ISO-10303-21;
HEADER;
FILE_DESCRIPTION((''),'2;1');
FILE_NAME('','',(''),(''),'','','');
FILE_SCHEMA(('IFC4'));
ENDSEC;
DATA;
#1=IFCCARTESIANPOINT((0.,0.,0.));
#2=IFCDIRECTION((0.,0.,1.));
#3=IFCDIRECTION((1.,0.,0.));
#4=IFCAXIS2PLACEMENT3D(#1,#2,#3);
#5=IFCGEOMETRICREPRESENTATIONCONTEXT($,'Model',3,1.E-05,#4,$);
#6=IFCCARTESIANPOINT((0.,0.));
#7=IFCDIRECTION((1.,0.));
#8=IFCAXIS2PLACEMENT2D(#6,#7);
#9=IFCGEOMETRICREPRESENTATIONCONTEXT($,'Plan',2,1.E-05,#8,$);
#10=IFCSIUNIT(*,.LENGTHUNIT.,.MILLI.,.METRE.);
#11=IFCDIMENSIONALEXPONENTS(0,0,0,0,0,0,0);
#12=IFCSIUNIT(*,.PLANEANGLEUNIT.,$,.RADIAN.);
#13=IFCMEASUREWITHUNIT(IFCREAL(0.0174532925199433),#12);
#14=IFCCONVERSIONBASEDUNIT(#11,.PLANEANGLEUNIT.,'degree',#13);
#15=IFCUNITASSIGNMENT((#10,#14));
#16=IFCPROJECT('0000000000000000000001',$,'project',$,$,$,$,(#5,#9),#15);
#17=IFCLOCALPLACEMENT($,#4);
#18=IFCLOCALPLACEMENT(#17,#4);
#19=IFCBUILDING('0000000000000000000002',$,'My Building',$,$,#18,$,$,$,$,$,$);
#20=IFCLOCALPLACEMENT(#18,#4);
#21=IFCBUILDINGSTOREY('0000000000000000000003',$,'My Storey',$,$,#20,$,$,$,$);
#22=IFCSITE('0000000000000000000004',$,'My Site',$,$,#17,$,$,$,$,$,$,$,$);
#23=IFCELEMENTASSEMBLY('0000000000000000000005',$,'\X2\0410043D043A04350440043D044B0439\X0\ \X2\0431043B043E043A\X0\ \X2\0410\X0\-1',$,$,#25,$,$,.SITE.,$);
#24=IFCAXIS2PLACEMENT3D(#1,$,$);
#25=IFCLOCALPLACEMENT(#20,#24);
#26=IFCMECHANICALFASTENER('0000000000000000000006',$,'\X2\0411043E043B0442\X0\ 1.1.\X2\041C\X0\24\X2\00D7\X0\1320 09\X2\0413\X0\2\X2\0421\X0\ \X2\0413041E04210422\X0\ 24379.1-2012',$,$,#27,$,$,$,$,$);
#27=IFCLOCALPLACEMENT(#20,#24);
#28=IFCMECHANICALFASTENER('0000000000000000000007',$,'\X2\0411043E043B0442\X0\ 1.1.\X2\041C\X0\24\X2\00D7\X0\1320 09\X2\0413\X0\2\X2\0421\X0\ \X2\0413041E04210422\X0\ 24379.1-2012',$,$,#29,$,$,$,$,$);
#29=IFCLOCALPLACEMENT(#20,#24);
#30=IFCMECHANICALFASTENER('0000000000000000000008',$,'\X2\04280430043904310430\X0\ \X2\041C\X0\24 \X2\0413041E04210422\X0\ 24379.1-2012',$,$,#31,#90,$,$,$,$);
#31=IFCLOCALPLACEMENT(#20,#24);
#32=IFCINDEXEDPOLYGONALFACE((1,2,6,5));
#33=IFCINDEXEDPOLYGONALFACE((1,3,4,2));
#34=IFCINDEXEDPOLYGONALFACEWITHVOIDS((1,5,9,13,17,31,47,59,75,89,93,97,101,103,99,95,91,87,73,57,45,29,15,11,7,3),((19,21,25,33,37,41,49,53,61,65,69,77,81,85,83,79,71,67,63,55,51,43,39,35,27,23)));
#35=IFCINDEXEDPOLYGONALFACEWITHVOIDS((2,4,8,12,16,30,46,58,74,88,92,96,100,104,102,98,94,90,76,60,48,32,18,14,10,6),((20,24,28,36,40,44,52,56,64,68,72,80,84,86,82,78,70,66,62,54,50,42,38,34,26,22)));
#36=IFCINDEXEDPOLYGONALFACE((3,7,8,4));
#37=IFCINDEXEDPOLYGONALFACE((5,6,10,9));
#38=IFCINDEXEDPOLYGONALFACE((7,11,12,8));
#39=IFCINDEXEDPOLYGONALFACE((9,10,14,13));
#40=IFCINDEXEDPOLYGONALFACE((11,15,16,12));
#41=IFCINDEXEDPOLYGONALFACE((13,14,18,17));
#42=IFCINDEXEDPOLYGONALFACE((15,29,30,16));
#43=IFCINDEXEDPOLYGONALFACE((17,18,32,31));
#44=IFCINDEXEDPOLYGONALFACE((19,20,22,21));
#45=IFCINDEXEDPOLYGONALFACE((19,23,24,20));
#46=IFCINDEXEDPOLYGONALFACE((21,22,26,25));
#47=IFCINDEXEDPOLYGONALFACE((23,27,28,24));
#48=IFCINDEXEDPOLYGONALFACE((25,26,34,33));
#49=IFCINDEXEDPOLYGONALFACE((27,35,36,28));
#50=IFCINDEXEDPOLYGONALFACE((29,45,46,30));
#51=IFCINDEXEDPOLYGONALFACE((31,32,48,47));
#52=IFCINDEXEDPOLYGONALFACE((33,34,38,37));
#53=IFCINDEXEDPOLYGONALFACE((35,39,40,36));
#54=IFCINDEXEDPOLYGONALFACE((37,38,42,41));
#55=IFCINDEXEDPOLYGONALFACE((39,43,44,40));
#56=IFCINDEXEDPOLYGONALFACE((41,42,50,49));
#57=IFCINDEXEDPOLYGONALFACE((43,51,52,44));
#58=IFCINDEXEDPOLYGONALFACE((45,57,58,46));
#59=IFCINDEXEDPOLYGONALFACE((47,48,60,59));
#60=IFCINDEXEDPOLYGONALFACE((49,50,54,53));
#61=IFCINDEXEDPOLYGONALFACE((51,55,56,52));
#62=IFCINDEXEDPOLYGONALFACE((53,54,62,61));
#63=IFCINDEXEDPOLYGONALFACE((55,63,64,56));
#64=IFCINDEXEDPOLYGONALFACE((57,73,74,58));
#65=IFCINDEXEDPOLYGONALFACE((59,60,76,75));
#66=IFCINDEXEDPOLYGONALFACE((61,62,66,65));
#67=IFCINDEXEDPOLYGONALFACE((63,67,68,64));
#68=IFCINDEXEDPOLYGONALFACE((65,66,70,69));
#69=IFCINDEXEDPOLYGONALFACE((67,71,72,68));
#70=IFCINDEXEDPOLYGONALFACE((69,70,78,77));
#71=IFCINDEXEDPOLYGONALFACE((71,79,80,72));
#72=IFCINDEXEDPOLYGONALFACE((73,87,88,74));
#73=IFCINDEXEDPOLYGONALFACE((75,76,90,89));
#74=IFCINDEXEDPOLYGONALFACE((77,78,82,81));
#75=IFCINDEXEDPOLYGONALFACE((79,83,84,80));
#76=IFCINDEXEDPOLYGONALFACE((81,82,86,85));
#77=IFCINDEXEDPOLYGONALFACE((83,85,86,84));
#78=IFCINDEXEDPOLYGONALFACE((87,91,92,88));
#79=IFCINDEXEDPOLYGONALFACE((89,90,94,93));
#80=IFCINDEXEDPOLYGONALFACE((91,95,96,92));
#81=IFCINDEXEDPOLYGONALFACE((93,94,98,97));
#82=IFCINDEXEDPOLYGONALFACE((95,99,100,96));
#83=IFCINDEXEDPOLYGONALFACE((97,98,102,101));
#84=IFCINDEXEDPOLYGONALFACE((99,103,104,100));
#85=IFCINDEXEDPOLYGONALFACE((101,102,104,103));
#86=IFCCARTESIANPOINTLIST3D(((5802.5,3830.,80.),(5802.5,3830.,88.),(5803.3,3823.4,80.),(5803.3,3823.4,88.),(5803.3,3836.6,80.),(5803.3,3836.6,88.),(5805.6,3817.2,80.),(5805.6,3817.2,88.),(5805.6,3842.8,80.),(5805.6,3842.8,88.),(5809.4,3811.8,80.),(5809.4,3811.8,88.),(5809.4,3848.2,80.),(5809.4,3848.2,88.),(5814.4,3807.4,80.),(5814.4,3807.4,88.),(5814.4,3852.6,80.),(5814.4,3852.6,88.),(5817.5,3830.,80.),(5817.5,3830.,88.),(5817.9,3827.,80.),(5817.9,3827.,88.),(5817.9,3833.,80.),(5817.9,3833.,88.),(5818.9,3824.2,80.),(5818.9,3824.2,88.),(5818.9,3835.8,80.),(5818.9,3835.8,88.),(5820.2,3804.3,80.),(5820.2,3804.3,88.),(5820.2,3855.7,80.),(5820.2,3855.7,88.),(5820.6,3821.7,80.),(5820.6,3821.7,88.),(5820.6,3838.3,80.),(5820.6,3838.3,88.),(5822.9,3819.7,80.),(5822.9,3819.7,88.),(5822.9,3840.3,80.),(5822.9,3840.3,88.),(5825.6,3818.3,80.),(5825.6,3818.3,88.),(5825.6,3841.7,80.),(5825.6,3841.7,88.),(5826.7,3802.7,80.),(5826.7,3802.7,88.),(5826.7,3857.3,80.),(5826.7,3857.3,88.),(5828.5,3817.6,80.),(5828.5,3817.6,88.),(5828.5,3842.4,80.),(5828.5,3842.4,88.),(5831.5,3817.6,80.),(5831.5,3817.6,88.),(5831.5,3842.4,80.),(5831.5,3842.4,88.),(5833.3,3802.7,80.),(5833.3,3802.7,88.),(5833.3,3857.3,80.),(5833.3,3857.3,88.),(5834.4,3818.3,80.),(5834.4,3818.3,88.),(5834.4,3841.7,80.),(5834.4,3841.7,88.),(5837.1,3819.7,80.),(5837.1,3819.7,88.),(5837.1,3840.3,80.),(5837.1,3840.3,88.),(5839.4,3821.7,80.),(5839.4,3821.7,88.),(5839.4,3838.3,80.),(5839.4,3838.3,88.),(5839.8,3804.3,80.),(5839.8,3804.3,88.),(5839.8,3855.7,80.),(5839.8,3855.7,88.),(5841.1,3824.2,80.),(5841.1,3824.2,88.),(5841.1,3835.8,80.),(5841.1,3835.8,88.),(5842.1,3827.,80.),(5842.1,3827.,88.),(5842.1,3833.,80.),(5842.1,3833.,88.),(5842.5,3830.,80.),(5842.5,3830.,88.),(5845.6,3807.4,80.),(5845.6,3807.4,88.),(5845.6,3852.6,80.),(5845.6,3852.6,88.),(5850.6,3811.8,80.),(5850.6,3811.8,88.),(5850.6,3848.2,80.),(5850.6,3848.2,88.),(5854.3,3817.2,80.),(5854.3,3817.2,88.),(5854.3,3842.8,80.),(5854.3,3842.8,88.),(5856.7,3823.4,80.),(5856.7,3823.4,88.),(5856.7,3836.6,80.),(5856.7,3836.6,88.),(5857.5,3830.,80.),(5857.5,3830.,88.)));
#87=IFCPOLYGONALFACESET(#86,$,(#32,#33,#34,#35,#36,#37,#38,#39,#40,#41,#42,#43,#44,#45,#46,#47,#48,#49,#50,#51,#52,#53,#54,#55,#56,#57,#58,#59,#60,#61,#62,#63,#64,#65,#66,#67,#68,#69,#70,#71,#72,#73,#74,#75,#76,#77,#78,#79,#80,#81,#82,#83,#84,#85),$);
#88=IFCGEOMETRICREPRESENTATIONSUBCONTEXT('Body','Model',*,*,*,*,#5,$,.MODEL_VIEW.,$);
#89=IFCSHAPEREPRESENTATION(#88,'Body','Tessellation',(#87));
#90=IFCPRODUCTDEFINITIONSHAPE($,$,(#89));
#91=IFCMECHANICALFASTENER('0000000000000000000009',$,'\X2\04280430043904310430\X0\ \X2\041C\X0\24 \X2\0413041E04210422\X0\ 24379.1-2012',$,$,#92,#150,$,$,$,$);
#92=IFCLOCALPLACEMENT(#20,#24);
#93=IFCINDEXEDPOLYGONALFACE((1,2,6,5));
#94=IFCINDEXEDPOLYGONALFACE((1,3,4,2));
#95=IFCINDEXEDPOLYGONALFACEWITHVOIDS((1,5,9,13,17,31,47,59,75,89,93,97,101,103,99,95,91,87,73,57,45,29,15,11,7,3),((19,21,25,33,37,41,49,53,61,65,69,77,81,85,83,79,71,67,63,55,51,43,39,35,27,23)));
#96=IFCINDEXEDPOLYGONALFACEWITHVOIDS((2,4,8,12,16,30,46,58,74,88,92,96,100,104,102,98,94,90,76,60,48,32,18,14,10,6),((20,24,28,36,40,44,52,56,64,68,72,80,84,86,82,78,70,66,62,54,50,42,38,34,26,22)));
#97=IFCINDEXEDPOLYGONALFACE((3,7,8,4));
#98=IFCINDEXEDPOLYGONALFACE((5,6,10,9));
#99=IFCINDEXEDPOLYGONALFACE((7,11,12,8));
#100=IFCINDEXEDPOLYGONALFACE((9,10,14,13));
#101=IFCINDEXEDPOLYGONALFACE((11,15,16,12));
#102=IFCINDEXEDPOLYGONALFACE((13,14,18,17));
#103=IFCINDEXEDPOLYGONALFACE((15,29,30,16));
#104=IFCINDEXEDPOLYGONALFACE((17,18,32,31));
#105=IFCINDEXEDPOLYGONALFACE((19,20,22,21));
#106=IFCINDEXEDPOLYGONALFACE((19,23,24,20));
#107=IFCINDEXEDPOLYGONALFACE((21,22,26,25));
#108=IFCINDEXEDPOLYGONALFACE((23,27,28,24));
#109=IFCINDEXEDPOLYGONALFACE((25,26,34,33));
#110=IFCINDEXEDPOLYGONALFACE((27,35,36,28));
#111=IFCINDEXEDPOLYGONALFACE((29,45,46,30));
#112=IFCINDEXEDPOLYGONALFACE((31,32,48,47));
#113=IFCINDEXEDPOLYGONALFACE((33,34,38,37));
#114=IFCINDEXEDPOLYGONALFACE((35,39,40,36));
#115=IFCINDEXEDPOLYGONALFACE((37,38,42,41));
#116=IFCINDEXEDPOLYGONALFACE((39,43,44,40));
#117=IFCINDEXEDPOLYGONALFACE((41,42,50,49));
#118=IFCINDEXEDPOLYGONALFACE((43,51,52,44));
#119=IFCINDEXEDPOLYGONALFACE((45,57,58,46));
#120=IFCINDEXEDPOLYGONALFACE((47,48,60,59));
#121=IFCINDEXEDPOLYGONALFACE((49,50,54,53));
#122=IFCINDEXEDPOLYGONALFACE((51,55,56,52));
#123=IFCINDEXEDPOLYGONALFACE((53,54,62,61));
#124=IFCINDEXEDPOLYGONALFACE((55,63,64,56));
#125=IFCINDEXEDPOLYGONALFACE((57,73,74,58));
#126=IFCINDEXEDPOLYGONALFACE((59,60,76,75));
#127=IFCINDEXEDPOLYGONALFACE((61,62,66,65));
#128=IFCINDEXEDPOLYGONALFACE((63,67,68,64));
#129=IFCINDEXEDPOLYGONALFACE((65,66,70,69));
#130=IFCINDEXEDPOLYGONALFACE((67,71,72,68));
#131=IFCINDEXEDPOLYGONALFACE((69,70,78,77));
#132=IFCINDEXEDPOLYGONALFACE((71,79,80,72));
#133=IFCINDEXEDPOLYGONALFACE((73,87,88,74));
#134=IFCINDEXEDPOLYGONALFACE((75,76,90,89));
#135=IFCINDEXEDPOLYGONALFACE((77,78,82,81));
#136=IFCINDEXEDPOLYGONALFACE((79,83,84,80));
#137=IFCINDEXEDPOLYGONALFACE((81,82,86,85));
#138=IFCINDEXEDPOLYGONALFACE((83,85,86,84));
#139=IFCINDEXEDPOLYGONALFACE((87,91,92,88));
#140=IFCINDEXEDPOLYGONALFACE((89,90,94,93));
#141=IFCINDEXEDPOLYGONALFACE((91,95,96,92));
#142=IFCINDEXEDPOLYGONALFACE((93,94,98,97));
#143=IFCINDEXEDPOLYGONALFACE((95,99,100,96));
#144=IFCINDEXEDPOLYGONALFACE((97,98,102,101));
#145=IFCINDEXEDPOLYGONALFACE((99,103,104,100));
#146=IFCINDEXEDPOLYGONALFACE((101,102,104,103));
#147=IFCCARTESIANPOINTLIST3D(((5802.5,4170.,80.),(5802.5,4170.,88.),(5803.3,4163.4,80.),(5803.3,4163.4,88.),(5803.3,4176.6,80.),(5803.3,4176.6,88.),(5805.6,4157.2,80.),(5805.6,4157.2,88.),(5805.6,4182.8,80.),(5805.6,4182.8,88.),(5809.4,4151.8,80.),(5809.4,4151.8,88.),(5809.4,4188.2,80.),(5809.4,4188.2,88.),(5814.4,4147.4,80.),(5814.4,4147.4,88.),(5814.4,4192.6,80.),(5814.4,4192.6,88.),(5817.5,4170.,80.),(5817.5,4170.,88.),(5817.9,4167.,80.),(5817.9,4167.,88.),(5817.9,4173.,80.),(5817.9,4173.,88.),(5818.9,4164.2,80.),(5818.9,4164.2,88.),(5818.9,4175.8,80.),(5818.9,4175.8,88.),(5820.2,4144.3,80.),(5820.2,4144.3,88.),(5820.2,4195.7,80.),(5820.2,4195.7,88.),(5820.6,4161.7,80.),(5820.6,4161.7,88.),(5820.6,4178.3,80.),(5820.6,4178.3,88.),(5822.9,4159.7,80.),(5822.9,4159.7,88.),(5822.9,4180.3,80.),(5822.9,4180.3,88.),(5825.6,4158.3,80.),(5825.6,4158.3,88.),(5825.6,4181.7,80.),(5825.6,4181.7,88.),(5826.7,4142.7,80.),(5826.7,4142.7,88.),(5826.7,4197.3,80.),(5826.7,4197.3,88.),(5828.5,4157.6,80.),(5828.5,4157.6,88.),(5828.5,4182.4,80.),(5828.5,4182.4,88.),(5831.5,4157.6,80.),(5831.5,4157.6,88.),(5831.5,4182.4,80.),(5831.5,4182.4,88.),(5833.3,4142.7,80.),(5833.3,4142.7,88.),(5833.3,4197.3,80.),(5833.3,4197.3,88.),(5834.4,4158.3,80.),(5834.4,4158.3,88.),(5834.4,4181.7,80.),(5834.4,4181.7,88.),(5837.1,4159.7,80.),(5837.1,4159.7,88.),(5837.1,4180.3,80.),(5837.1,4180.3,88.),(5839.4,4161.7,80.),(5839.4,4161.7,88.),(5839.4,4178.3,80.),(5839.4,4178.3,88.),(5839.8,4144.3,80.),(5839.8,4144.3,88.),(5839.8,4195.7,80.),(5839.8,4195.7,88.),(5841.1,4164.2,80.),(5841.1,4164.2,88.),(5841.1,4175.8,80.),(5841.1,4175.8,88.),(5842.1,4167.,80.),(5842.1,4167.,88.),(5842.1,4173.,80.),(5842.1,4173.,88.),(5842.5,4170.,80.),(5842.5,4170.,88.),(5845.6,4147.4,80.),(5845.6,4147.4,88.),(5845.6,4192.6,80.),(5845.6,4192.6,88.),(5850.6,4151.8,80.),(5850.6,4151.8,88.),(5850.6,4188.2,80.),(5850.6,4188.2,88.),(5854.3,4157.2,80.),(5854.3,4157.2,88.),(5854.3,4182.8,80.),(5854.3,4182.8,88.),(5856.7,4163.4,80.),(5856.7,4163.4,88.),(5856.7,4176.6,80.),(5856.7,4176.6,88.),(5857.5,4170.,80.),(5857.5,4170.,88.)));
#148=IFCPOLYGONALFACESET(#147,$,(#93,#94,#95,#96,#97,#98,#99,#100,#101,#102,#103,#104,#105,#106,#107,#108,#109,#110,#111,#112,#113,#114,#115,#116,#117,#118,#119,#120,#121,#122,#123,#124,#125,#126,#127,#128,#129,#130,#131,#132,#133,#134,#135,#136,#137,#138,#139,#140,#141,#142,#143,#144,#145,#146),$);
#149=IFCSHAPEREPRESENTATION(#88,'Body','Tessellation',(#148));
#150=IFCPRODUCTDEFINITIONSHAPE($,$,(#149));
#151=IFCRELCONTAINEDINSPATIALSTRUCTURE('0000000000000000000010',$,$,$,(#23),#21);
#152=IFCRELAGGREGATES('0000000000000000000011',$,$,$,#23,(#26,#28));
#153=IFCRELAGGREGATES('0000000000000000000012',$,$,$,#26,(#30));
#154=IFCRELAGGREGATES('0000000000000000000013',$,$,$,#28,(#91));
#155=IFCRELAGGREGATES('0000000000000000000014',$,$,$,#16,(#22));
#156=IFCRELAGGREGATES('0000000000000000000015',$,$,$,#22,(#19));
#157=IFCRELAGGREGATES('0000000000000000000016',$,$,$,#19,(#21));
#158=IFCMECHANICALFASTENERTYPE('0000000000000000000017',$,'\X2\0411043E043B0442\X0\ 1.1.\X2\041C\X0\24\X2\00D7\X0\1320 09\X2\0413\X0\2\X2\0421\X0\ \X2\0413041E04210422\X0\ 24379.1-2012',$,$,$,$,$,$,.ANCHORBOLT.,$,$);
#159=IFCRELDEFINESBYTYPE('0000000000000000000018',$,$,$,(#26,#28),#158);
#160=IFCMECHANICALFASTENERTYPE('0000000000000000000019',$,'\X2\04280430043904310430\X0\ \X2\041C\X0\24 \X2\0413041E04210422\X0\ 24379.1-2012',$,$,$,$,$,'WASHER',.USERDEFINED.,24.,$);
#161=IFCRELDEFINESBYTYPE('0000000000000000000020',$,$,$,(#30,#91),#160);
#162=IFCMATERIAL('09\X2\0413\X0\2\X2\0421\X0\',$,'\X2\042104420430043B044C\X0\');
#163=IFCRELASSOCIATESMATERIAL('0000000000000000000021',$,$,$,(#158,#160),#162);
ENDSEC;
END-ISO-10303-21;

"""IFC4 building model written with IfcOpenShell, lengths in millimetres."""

from ifc_helpers import new_model, entity, si_unit, converted_unit, frame, origin_with_axes, origin_2d_with_axis, place, context, subcontext, project, spatial, polyline, outline, extrude, source, transform, mapped, material, type_object, type_shapes, element, aggregate, save


model = new_model("IFC4")

# Units and contexts
model_context = context("Model", 3, precision=1e-05, world=origin_with_axes())
plan_context = context("Plan", 2, precision=1e-05, world=origin_2d_with_axis())
body_context = subcontext(model_context, "Body", "Model", "MODEL_VIEW")
ifc_project = project(units=[si_unit("LENGTHUNIT", "METRE", prefix="MILLI"), converted_unit("PLANEANGLEUNIT", "degree", entity("IfcReal", 0.0174532925199433), si_unit("PLANEANGLEUNIT", "RADIAN"), dimensions=[0, 0, 0, 0, 0, 0, 0])], contexts=[model_context, plan_context])

# Site, building, storey
site_placement = place(None, origin_with_axes())
site = spatial("IfcSite", under=ifc_project, at=site_placement, Name="My Site")
building_placement = place(site_placement, origin_with_axes())
building = spatial("IfcBuilding", under=site, at=building_placement, Name="My Building")
storey_placement = place(building_placement, origin_with_axes())
storey = spatial("IfcBuildingStorey", under=building, at=storey_placement, Name="My Storey")

# Element assembly, mechanical fasteners
ifc_material_1 = material(Name="09Г2С", Category="Сталь")
mechanical_fastener_type_1 = type_object("IfcMechanicalFastenerType", Name="Болт 1.1.М24×1320 09Г2С ГОСТ 24379.1-2012", PredefinedType="ANCHORBOLT", material=ifc_material_1)
assembly_1_placement = place(storey_placement, frame((6000.0, 4000.0, 0.0), z_axis=(0.0, 0.0, 1.0), x_axis=(1.0, 0.0, 0.0)))
assembly_1 = element("IfcElementAssembly", 1, at=assembly_1_placement, inside=storey, Name="Анкерный блок А-1", AssemblyPlace="SITE")
mechanical_fastener_1_placement = place(assembly_1_placement, frame((-170.0, -170.0, 0.0), z_axis=(0.0, 0.0, 1.0), x_axis=(1.0, 0.0, 0.0)))
mechanical_fastener_1 = element("IfcMechanicalFastener", 2, at=mechanical_fastener_1_placement, type_object=mechanical_fastener_type_1, Name="Болт 1.1.М24×1320 09Г2С ГОСТ 24379.1-2012")
mechanical_fastener_2_placement = place(assembly_1_placement, frame((-170.0, 170.0, 0.0), z_axis=(0.0, 0.0, 1.0), x_axis=(-1.0, 0.0, 0.0)))
mechanical_fastener_2 = element("IfcMechanicalFastener", 3, at=mechanical_fastener_2_placement, type_object=mechanical_fastener_type_1, Name="Болт 1.1.М24×1320 09Г2С ГОСТ 24379.1-2012")
aggregate(assembly_1, [mechanical_fastener_1, mechanical_fastener_2])

# Mechanical fasteners
mechanical_fastener_type_2 = type_object("IfcMechanicalFastenerType", Name="Шайба М24 ГОСТ 24379.1-2012", ElementType="WASHER", NominalDiameter=24.0, PredefinedType="USERDEFINED", material=ifc_material_1)
shared_shape_1 = source(origin_with_axes(), body_context, "Body", "SweptSolid", [
    extrude(outline(polyline([(27.5, 0.0), (26.7, 6.6), (24.4, 12.8), (20.6, 18.2), (15.6, 22.6), (9.8, 25.7), (3.3, 27.3), (-3.3, 27.3), (-9.8, 25.7), (-15.6, 22.6), (-20.6, 18.2), (-24.4, 12.8), (-26.7, 6.6), (-27.5, 0.0), (-26.7, -6.6), (-24.4, -12.8), (-20.6, -18.2), (-15.6, -22.6), (-9.8, -25.7), (-3.3, -27.3), (3.3, -27.3), (9.8, -25.7), (15.6, -22.6), (20.6, -18.2), (24.4, -12.8), (26.7, -6.6), (27.5, 0.0)]), holes=[polyline([(-4.4, -11.7), (-7.1, -10.3), (-9.4, -8.3), (-11.1, -5.8), (-12.1, -3.0), (-12.5, 0.0), (-12.1, 3.0), (-11.1, 5.8), (-9.4, 8.3), (-7.1, 10.3), (-4.4, 11.7), (-1.5, 12.4), (1.5, 12.4), (4.4, 11.7), (7.1, 10.3), (9.4, 8.3), (11.1, 5.8), (12.1, 3.0), (12.5, 0.0), (12.1, -3.0), (11.1, -5.8), (9.4, -8.3), (7.1, -10.3), (4.4, -11.7), (1.5, -12.4), (-1.5, -12.4), (-4.4, -11.7)])]), frame((0.0, 0.0, 0.0), z_axis=(0.0, 0.0, 1.0), x_axis=(0.120537, -0.992709, 0.0)), (0.0, 0.0, 1.0), 8.0),
])
type_shapes(mechanical_fastener_type_2, [shared_shape_1])
mechanical_fastener_3_placement = place(mechanical_fastener_1_placement, frame((0.0, 0.0, 80.0), z_axis=(0.0, 0.0, 1.0), x_axis=(1.0, 0.0, 0.0)))
mechanical_fastener_3 = element("IfcMechanicalFastener", 4, at=mechanical_fastener_3_placement, type_object=mechanical_fastener_type_2, Name="Шайба М24 ГОСТ 24379.1-2012", context=body_context, shape_type="MappedRepresentation", body=[
    mapped(shared_shape_1, transform((0.0, 0.0, 0.0), x_axis=(1.0, 0.0, 0.0), y_axis=(0.0, 1.0, 0.0), z_axis=(0.0, 0.0, 1.0), scale=1.0)),
])
aggregate(mechanical_fastener_1, [mechanical_fastener_3])
mechanical_fastener_4_placement = place(mechanical_fastener_2_placement, frame((0.0, 0.0, 80.0), z_axis=(0.0, 0.0, 1.0), x_axis=(1.0, 0.0, 0.0)))
mechanical_fastener_4 = element("IfcMechanicalFastener", 5, at=mechanical_fastener_4_placement, type_object=mechanical_fastener_type_2, Name="Шайба М24 ГОСТ 24379.1-2012", context=body_context, shape_type="MappedRepresentation", body=[
    mapped(shared_shape_1, transform((0.0, 0.0, 0.0), x_axis=(1.0, 0.0, 0.0), y_axis=(0.0, 1.0, 0.0), z_axis=(0.0, 0.0, 1.0), scale=1.0)),
])
aggregate(mechanical_fastener_2, [mechanical_fastener_4])

save(model, "model.ifc")
